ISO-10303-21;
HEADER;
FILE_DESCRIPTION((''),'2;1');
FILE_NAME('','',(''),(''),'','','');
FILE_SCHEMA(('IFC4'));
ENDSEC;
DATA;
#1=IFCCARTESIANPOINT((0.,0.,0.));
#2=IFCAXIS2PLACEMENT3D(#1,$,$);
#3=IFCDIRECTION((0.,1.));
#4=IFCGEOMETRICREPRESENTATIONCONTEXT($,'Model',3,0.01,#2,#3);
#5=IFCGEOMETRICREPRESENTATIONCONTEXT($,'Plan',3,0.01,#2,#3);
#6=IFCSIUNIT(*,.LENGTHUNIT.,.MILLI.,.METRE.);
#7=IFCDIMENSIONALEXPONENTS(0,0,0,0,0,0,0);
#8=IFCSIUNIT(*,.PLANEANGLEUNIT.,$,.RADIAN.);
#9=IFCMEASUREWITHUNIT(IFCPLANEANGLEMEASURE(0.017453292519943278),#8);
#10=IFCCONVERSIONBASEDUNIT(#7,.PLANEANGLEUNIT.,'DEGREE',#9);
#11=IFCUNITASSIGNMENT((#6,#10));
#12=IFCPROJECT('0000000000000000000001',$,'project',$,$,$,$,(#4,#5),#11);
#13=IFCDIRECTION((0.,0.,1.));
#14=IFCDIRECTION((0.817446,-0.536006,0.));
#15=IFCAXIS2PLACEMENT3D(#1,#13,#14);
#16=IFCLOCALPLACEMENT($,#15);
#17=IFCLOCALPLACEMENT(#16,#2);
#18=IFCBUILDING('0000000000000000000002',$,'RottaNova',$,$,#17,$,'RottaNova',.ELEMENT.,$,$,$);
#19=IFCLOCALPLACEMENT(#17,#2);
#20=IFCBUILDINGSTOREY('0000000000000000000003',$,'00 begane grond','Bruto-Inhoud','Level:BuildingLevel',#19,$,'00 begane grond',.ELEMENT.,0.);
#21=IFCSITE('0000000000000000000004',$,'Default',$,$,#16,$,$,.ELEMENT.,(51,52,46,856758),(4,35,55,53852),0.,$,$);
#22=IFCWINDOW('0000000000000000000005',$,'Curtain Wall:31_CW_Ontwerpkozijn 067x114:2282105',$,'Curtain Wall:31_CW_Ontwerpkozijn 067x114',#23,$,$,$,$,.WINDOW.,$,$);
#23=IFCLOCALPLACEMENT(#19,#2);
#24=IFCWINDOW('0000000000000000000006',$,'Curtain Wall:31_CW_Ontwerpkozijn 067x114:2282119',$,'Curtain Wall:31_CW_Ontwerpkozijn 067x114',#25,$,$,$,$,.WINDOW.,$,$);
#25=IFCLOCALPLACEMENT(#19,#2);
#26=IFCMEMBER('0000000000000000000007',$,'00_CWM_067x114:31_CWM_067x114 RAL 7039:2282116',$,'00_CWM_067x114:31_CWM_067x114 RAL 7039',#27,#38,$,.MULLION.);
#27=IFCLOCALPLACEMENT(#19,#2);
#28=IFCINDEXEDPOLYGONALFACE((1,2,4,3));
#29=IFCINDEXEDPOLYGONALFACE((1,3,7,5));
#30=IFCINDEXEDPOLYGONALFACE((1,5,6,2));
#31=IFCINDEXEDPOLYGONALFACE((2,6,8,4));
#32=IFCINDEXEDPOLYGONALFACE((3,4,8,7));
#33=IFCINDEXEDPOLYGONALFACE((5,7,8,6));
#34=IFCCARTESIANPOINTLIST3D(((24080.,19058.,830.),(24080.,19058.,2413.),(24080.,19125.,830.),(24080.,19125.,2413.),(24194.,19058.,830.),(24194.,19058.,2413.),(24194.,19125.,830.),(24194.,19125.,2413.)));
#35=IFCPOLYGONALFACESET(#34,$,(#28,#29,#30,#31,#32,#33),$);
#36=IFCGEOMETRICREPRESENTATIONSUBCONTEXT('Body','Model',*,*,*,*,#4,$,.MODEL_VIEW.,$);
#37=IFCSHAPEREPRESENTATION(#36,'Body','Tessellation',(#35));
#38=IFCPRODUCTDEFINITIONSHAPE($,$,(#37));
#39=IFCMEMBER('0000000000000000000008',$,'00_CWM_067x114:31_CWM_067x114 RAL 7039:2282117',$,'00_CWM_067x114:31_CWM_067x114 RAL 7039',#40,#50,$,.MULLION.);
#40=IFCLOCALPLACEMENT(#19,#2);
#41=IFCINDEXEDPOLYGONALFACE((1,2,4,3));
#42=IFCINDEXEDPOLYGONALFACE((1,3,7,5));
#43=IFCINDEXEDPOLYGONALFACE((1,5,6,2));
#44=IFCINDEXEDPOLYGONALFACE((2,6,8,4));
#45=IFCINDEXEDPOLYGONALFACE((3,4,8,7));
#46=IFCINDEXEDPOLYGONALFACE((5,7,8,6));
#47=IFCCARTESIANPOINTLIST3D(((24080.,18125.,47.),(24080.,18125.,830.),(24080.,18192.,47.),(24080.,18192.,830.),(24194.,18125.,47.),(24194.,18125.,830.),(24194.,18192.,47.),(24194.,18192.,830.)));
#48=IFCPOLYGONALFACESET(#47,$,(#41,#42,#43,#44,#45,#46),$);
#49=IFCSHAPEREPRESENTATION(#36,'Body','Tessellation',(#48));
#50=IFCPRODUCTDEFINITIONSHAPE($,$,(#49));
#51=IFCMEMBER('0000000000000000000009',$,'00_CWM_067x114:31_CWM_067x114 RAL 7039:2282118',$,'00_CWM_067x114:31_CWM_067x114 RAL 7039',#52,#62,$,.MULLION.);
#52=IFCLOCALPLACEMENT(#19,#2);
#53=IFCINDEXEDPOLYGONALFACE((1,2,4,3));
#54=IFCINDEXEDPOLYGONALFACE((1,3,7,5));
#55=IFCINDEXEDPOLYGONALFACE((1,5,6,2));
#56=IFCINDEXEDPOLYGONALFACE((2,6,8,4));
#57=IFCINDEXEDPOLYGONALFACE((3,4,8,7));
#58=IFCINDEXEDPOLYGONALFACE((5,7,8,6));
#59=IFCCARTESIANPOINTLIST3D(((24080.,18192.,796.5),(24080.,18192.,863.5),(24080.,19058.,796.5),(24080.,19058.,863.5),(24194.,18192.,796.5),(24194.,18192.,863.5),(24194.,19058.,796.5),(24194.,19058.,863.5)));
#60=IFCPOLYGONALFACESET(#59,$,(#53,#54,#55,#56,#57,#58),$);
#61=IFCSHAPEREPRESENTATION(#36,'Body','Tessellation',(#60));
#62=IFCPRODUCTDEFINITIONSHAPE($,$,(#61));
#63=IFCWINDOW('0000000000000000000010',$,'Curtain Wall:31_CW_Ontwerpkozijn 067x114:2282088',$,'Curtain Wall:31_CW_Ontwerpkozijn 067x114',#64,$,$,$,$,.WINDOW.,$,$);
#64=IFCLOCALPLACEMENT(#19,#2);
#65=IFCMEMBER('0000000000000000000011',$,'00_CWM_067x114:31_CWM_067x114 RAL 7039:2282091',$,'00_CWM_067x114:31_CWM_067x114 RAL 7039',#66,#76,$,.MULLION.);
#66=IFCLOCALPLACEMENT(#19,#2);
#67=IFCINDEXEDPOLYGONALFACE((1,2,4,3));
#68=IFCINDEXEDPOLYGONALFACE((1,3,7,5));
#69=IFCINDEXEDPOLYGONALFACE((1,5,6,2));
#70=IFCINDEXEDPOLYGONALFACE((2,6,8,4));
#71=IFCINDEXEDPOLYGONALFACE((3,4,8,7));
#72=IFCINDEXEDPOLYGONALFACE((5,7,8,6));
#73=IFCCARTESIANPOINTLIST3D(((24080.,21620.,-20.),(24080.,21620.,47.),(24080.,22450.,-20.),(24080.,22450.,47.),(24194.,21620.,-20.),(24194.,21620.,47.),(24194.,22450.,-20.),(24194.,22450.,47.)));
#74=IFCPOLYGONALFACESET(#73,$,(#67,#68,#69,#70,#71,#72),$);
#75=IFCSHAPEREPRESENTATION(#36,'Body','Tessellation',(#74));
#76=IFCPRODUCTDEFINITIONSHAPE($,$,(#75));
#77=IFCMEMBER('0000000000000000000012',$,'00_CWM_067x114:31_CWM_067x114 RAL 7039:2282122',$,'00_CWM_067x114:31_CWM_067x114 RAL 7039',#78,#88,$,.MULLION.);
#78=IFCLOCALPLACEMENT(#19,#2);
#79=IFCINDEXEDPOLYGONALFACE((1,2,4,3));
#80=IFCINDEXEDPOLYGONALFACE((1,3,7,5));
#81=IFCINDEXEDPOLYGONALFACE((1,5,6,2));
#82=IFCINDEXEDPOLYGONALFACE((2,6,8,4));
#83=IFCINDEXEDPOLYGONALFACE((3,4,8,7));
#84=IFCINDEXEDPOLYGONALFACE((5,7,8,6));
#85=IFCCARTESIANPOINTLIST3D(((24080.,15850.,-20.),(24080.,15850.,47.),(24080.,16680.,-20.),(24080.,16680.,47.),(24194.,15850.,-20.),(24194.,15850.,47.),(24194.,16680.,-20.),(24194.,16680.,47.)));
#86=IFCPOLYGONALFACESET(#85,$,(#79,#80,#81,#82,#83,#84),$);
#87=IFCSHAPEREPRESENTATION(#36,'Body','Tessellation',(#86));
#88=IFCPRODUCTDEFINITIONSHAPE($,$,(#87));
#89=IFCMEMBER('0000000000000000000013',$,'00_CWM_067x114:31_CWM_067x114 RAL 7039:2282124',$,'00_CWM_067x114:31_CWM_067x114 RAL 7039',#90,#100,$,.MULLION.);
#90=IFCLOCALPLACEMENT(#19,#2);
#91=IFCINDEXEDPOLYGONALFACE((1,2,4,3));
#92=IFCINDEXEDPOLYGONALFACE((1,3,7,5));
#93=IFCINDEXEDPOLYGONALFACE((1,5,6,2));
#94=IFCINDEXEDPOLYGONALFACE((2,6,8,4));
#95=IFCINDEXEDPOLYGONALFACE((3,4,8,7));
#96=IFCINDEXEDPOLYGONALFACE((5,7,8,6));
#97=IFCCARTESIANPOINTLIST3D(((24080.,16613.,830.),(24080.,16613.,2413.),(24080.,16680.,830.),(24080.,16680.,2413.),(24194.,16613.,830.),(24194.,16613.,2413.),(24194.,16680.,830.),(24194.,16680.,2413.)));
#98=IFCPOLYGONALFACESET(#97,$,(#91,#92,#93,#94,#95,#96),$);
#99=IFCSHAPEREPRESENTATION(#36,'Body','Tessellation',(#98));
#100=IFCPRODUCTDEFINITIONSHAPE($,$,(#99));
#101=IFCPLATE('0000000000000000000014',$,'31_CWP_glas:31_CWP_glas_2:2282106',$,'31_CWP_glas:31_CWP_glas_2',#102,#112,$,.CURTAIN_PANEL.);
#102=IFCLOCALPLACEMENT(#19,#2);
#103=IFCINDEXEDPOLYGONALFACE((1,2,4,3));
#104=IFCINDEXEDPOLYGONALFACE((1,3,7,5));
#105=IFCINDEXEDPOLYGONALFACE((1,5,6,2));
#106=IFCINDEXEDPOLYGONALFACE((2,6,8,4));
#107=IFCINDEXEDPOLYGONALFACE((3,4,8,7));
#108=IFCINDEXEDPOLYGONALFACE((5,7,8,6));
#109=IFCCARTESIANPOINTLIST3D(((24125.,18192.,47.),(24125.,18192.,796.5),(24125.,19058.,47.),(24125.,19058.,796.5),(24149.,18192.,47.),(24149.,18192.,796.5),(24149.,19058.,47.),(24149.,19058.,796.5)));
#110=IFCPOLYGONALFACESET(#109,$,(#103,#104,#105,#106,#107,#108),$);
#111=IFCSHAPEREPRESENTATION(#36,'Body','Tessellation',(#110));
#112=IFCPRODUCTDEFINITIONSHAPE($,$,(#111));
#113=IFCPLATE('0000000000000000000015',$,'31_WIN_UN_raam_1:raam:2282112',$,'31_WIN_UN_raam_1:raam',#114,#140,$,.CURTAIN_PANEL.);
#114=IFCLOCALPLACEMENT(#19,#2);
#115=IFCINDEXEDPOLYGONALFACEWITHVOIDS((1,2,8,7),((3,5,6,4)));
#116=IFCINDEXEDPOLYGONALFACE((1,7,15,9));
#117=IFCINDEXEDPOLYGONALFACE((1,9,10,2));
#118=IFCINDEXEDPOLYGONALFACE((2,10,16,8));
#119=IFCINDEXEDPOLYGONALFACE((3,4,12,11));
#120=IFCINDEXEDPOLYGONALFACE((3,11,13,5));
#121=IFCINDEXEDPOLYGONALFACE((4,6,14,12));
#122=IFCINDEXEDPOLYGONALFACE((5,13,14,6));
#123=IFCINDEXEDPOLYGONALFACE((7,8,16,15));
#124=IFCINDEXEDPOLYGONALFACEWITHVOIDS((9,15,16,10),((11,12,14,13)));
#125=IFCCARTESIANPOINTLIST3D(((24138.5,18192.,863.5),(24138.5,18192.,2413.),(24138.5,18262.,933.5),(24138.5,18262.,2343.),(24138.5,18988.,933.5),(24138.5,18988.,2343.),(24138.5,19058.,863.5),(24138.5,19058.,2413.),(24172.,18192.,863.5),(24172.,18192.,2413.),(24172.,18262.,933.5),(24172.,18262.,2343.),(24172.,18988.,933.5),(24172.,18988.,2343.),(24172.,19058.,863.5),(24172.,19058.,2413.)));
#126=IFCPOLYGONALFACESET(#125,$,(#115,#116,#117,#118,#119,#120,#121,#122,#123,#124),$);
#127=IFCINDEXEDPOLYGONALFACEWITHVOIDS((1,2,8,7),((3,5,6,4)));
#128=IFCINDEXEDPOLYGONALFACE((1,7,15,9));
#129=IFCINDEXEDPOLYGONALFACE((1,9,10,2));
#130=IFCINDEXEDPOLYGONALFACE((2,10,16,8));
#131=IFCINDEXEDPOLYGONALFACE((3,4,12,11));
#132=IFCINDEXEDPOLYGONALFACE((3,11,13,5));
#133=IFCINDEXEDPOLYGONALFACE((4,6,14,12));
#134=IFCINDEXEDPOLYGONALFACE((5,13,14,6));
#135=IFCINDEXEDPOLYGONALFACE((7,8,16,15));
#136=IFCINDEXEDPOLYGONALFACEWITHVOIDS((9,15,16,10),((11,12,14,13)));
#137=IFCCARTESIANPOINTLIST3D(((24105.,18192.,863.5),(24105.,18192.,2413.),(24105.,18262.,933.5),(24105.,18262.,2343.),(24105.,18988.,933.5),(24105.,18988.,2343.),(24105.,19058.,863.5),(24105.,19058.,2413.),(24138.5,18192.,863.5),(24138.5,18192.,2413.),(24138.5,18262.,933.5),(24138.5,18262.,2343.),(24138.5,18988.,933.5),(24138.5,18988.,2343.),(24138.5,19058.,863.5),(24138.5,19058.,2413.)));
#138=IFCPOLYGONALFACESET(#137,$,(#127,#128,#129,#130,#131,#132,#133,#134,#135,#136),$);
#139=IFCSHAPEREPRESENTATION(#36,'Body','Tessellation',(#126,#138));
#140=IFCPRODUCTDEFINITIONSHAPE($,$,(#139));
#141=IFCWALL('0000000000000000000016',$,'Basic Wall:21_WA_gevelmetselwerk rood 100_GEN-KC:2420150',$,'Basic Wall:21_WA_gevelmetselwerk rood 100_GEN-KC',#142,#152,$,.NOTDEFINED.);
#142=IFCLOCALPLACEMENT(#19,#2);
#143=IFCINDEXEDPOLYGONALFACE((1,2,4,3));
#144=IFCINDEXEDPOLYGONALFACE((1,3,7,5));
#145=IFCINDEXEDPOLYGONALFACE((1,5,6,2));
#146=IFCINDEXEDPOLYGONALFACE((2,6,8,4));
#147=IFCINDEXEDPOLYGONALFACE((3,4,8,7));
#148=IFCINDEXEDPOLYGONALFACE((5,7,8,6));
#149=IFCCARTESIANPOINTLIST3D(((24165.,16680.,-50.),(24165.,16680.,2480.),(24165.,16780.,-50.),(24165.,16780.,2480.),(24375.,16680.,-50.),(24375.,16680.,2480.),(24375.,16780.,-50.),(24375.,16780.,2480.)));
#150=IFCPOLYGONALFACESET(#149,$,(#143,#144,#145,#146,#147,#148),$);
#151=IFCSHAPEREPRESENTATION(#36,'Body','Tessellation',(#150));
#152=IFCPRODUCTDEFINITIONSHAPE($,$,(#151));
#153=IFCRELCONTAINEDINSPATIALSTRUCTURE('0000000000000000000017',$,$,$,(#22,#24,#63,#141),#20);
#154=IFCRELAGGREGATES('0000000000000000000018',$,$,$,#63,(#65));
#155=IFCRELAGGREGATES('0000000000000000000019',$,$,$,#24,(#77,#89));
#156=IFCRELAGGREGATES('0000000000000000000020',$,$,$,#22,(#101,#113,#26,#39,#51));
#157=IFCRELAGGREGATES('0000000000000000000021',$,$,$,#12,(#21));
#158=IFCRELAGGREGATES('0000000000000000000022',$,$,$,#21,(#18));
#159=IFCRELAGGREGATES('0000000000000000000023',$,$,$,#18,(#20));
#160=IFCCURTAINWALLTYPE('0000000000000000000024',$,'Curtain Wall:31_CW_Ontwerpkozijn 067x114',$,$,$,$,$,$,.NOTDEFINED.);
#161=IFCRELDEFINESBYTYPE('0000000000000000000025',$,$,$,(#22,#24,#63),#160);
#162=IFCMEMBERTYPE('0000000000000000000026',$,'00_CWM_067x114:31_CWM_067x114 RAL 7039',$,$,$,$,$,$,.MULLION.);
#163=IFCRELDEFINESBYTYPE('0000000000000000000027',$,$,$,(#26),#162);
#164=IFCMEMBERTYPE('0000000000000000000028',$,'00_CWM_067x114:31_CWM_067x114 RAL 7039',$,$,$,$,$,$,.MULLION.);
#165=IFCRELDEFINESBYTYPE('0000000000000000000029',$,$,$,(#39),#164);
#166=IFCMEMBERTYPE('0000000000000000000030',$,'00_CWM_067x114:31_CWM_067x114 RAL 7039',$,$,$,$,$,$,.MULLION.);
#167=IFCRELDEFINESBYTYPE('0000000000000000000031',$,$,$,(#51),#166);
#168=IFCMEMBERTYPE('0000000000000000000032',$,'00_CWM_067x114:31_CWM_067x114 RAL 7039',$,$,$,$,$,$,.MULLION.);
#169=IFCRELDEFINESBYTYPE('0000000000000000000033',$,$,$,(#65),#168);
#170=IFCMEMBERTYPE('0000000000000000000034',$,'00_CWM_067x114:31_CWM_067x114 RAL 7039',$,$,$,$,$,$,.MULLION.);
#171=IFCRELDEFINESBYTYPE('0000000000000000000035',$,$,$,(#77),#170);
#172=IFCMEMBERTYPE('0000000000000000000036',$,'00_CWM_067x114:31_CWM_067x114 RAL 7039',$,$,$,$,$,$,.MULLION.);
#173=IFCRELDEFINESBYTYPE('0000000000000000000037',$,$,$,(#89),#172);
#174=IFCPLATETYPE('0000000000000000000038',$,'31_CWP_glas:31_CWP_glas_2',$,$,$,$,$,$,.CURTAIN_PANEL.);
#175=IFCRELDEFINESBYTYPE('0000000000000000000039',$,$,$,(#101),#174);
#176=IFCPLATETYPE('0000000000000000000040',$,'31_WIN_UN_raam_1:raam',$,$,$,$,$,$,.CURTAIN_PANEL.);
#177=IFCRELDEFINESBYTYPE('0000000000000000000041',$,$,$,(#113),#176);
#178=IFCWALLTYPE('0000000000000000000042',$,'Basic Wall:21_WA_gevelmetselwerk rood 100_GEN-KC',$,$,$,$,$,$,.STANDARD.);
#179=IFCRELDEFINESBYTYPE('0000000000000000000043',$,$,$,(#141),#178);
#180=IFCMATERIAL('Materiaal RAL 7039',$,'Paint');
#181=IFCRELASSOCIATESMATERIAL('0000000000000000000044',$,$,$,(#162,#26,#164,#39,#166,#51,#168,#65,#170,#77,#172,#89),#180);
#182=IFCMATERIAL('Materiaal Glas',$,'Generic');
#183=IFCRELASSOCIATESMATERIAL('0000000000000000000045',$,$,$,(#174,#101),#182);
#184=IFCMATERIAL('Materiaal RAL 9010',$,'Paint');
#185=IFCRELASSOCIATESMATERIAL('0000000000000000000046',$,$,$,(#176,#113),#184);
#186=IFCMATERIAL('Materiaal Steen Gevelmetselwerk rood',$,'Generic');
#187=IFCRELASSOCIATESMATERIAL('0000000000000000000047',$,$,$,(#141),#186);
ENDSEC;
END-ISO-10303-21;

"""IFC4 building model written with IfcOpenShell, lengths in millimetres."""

from ifc_helpers import new_model, entity, si_unit, converted_unit, direction, frame, origin, place, context, subcontext, project, spatial, indexed_curve, outline, extrude, source, transform, mapped, material, type_object, type_shapes, element, aggregate, save


model = new_model("IFC4")

# Units and contexts
model_context = context("Model", 3, precision=0.01, world=origin(), true_north=direction((0.0, 1.0)))
plan_context = context("Plan", 3, precision=0.01, world=origin(), true_north=direction((0.0, 1.0)))
body_context = subcontext(model_context, "Body", "Model", "MODEL_VIEW")
ifc_project = project(units=[si_unit("LENGTHUNIT", "METRE", prefix="MILLI"), converted_unit("PLANEANGLEUNIT", "DEGREE", entity("IfcPlaneAngleMeasure", 0.017453292519943278), si_unit("PLANEANGLEUNIT", "RADIAN"), dimensions=[0, 0, 0, 0, 0, 0, 0])], contexts=[model_context, plan_context])

# Site, building, storey
site_placement = place(None, frame((0.0, 0.0, 0.0), z_axis=(0.0, 0.0, 1.0), x_axis=(0.817446, -0.536006, 0.0)))
site = spatial("IfcSite", under=ifc_project, at=site_placement, Name="Default", CompositionType="ELEMENT", RefLatitude=(51, 52, 46, 856758), RefLongitude=(4, 35, 55, 53852), RefElevation=0.0)
building_placement = place(site_placement, origin())
building = spatial("IfcBuilding", under=site, at=building_placement, Name="RottaNova", LongName="RottaNova", CompositionType="ELEMENT")
storey_placement = place(building_placement, origin())
storey = spatial("IfcBuildingStorey", under=building, at=storey_placement, Name="00 begane grond", Description="Bruto-Inhoud", ObjectType="Level:BuildingLevel", LongName="00 begane grond", CompositionType="ELEMENT", Elevation=0.0)

# Shared definitions
curtain_wall_type = type_object("IfcCurtainWallType", Name="Curtain Wall:31_CW_Ontwerpkozijn 067x114", PredefinedType="NOTDEFINED")
ifc_material_1 = material(Name="Materiaal RAL 7039", Category="Paint")

# Window
window_1_placement = place(storey_placement, origin())
window_1 = element("IfcWindow", 1, at=window_1_placement, inside=storey, type_object=curtain_wall_type, Name="Curtain Wall:31_CW_Ontwerpkozijn 067x114:2282105", ObjectType="Curtain Wall:31_CW_Ontwerpkozijn 067x114", PredefinedType="WINDOW")

# Window
window_2_placement = place(storey_placement, origin())
window_2 = element("IfcWindow", 2, at=window_2_placement, inside=storey, type_object=curtain_wall_type, Name="Curtain Wall:31_CW_Ontwerpkozijn 067x114:2282119", ObjectType="Curtain Wall:31_CW_Ontwerpkozijn 067x114", PredefinedType="WINDOW")

# Members
member_type_1 = type_object("IfcMemberType", Name="00_CWM_067x114:31_CWM_067x114 RAL 7039", PredefinedType="MULLION", material=ifc_material_1)
shared_shape_1 = source(origin(), body_context, "Body", "SweptSolid", [
    extrude(outline(indexed_curve([(-33.5, -57.0), (33.5, -57.0), (33.5, 57.0), (-33.5, 57.0), (-33.5, -57.0)], self_intersect=False)), frame((-33.5, 57.0, -1583.0), z_axis=(0.0, 0.0, 1.0), x_axis=(-1.0, 0.0, 0.0)), (0.0, 0.0, 1.0), 1583.0),
])
type_shapes(member_type_1, [shared_shape_1])
member_1_placement = place(window_1_placement, frame((24080.0, 19125.0, 830.0), z_axis=(0.0, 0.0, -1.0), x_axis=(0.0, 1.0, 0.0)))
member_1 = element("IfcMember", 3, at=member_1_placement, type_object=member_type_1, material=ifc_material_1, Name="00_CWM_067x114:31_CWM_067x114 RAL 7039:2282116", ObjectType="00_CWM_067x114:31_CWM_067x114 RAL 7039", PredefinedType="MULLION", context=body_context, shape_type="MappedRepresentation", body=[
    mapped(shared_shape_1, transform((0.0, 0.0, 0.0), scale=1.0)),
])
member_type_2 = type_object("IfcMemberType", Name="00_CWM_067x114:31_CWM_067x114 RAL 7039", PredefinedType="MULLION", material=ifc_material_1)
shared_shape_2 = source(origin(), body_context, "Body", "SweptSolid", [
    extrude(outline(indexed_curve([(-33.5, -57.0), (33.5, -57.0), (33.5, 57.0), (-33.5, 57.0), (-33.5, -57.0)], self_intersect=False)), frame((-33.5, 57.0, -783.0), z_axis=(0.0, 0.0, 1.0), x_axis=(-1.0, 0.0, 0.0)), (0.0, 0.0, 1.0), 783.0),
])
type_shapes(member_type_2, [shared_shape_2])
member_2_placement = place(window_1_placement, frame((24080.0, 18125.0, 830.0), z_axis=(0.0, 0.0, 1.0), x_axis=(0.0, -1.0, 0.0)))
member_2 = element("IfcMember", 4, at=member_2_placement, type_object=member_type_2, material=ifc_material_1, Name="00_CWM_067x114:31_CWM_067x114 RAL 7039:2282117", ObjectType="00_CWM_067x114:31_CWM_067x114 RAL 7039", PredefinedType="MULLION", context=body_context, shape_type="MappedRepresentation", body=[
    mapped(shared_shape_2, transform((0.0, 0.0, 0.0), scale=1.0)),
])
member_type_3 = type_object("IfcMemberType", Name="00_CWM_067x114:31_CWM_067x114 RAL 7039", PredefinedType="MULLION", material=ifc_material_1)
shared_shape_3 = source(origin(), body_context, "Body", "SweptSolid", [
    extrude(outline(indexed_curve([(-33.5, -57.0), (33.5, -57.0), (33.5, 57.0), (-33.5, 57.0), (-33.5, -57.0)], self_intersect=False)), frame((0.0, 57.0, -866.0), z_axis=(0.0, 0.0, 1.0), x_axis=(-1.0, 0.0, 0.0)), (0.0, 0.0, 1.0), 866.0),
])
type_shapes(member_type_3, [shared_shape_3])
member_3_placement = place(window_1_placement, frame((24080.0, 19058.0, 830.0), z_axis=(0.0, 1.0, 0.0), x_axis=(0.0, 0.0, 1.0)))
member_3 = element("IfcMember", 5, at=member_3_placement, type_object=member_type_3, material=ifc_material_1, Name="00_CWM_067x114:31_CWM_067x114 RAL 7039:2282118", ObjectType="00_CWM_067x114:31_CWM_067x114 RAL 7039", PredefinedType="MULLION", context=body_context, shape_type="MappedRepresentation", body=[
    mapped(shared_shape_3, transform((0.0, 0.0, 0.0), scale=1.0)),
])

# Window, member
window_3_placement = place(storey_placement, origin())
window_3 = element("IfcWindow", 6, at=window_3_placement, inside=storey, type_object=curtain_wall_type, Name="Curtain Wall:31_CW_Ontwerpkozijn 067x114:2282088", ObjectType="Curtain Wall:31_CW_Ontwerpkozijn 067x114", PredefinedType="WINDOW")
member_type_4 = type_object("IfcMemberType", Name="00_CWM_067x114:31_CWM_067x114 RAL 7039", PredefinedType="MULLION", material=ifc_material_1)
shared_shape_4 = source(origin(), body_context, "Body", "SweptSolid", [
    extrude(outline(indexed_curve([(-33.5, -57.0), (33.5, -57.0), (33.5, 57.0), (-33.5, 57.0), (-33.5, -57.0)], self_intersect=False)), frame((-33.5, 57.0, -830.0), z_axis=(0.0, 0.0, 1.0), x_axis=(-1.0, 0.0, 0.0)), (0.0, 0.0, 1.0), 830.0),
])
type_shapes(member_type_4, [shared_shape_4])
member_4_placement = place(window_3_placement, frame((24080.0, 21620.0, -20.0), z_axis=(0.0, -1.0, 0.0), x_axis=(0.0, 0.0, -1.0)))
member_4 = element("IfcMember", 7, at=member_4_placement, type_object=member_type_4, material=ifc_material_1, Name="00_CWM_067x114:31_CWM_067x114 RAL 7039:2282091", ObjectType="00_CWM_067x114:31_CWM_067x114 RAL 7039", PredefinedType="MULLION", context=body_context, shape_type="MappedRepresentation", body=[
    mapped(shared_shape_4, transform((0.0, 0.0, 0.0), scale=1.0)),
])
aggregate(window_3, [member_4])

# Members
member_type_5 = type_object("IfcMemberType", Name="00_CWM_067x114:31_CWM_067x114 RAL 7039", PredefinedType="MULLION", material=ifc_material_1)
shared_shape_5 = source(origin(), body_context, "Body", "SweptSolid", [
    extrude(outline(indexed_curve([(-33.5, -57.0), (33.5, -57.0), (33.5, 57.0), (-33.5, 57.0), (-33.5, -57.0)], self_intersect=False)), frame((-33.5, -57.0, -830.0), z_axis=(0.0, 0.0, 1.0), x_axis=(-1.0, 0.0, 0.0)), (0.0, 0.0, 1.0), 830.0),
])
type_shapes(member_type_5, [shared_shape_5])
member_5_placement = place(window_2_placement, frame((24080.0, 16680.0, -20.0), z_axis=(0.0, 1.0, 0.0), x_axis=(0.0, 0.0, -1.0)))
member_5 = element("IfcMember", 8, at=member_5_placement, type_object=member_type_5, material=ifc_material_1, Name="00_CWM_067x114:31_CWM_067x114 RAL 7039:2282122", ObjectType="00_CWM_067x114:31_CWM_067x114 RAL 7039", PredefinedType="MULLION", context=body_context, shape_type="MappedRepresentation", body=[
    mapped(shared_shape_5, transform((0.0, 0.0, 0.0), scale=1.0)),
])
member_type_6 = type_object("IfcMemberType", Name="00_CWM_067x114:31_CWM_067x114 RAL 7039", PredefinedType="MULLION", material=ifc_material_1)
shared_shape_6 = source(origin(), body_context, "Body", "SweptSolid", [
    extrude(outline(indexed_curve([(-33.5, -57.0), (33.5, -57.0), (33.5, 57.0), (-33.5, 57.0), (-33.5, -57.0)], self_intersect=False)), frame((-33.5, -57.0, -1583.0), z_axis=(0.0, 0.0, 1.0), x_axis=(-1.0, 0.0, 0.0)), (0.0, 0.0, 1.0), 1583.0),
])
type_shapes(member_type_6, [shared_shape_6])
member_6_placement = place(window_2_placement, frame((24080.0, 16680.0, 2413.0), z_axis=(0.0, 0.0, 1.0), x_axis=(0.0, 1.0, 0.0)))
member_6 = element("IfcMember", 9, at=member_6_placement, type_object=member_type_6, material=ifc_material_1, Name="00_CWM_067x114:31_CWM_067x114 RAL 7039:2282124", ObjectType="00_CWM_067x114:31_CWM_067x114 RAL 7039", PredefinedType="MULLION", context=body_context, shape_type="MappedRepresentation", body=[
    mapped(shared_shape_6, transform((0.0, 0.0, 0.0), scale=1.0)),
])
aggregate(window_2, [member_5, member_6])

# Plates
ifc_material_2 = material(Name="Materiaal Glas", Category="Generic")
plate_type_1 = type_object("IfcPlateType", Name="31_CWP_glas:31_CWP_glas_2", PredefinedType="CURTAIN_PANEL", material=ifc_material_2)
shared_shape_7 = source(origin(), body_context, "Body", "SweptSolid", [
    extrude(outline(indexed_curve([(-12.0, -433.0), (12.0, -433.0), (12.0, 433.0), (-12.0, 433.0), (-12.0, -433.0)], self_intersect=False)), frame((0.0, -57.0, 0.0), z_axis=(0.0, 0.0, 1.0), x_axis=(0.0, 1.0, 0.0)), (0.0, 0.0, 1.0), 749.5),
])
type_shapes(plate_type_1, [shared_shape_7])
plate_1_placement = place(window_1_placement, frame((24080.0, 18625.0, 47.0), z_axis=(0.0, 0.0, 1.0), x_axis=(0.0, 1.0, 0.0)))
plate_1 = element("IfcPlate", 10, at=plate_1_placement, type_object=plate_type_1, material=ifc_material_2, Name="31_CWP_glas:31_CWP_glas_2:2282106", ObjectType="31_CWP_glas:31_CWP_glas_2", PredefinedType="CURTAIN_PANEL", context=body_context, shape_type="MappedRepresentation", body=[
    mapped(shared_shape_7, transform((0.0, 0.0, 0.0), scale=1.0)),
])
ifc_material_3 = material(Name="Materiaal RAL 9010", Category="Paint")
plate_type_2 = type_object("IfcPlateType", Name="31_WIN_UN_raam_1:raam", PredefinedType="CURTAIN_PANEL", material=ifc_material_3)
shared_shape_8 = source(origin(), body_context, "Body", "SweptSolid", [
    extrude(outline(indexed_curve([(-433.0, -774.7), (433.0, -774.7), (433.0, 774.7), (-433.0, 774.7), (-433.0, -774.7)], self_intersect=False), holes=[indexed_curve([(-363.0, 704.7), (363.0, 704.7), (363.0, -704.8), (-363.0, -704.8), (-363.0, 704.7)], self_intersect=False)]), frame((0.0, -92.0, 774.8), z_axis=(0.0, 1.0, 0.0), x_axis=(1.0, 0.0, 0.0)), (0.0, 0.0, 1.0), 33.5),
    extrude(outline(indexed_curve([(-433.0, -774.7), (433.0, -774.7), (433.0, 774.7), (-433.0, 774.7), (-433.0, -774.7)], self_intersect=False), holes=[indexed_curve([(-363.0, 704.7), (363.0, 704.7), (363.0, -704.8), (-363.0, -704.8), (-363.0, 704.7)], self_intersect=False)]), frame((0.0, -58.5, 774.8), z_axis=(0.0, 1.0, 0.0), x_axis=(1.0, 0.0, 0.0)), (0.0, 0.0, 1.0), 33.5),
])
type_shapes(plate_type_2, [shared_shape_8])
plate_2_placement = place(window_1_placement, frame((24080.0, 18625.0, 863.5), z_axis=(0.0, 0.0, 1.0), x_axis=(0.0, 1.0, 0.0)))
plate_2 = element("IfcPlate", 11, at=plate_2_placement, type_object=plate_type_2, material=ifc_material_3, Name="31_WIN_UN_raam_1:raam:2282112", ObjectType="31_WIN_UN_raam_1:raam", PredefinedType="CURTAIN_PANEL", context=body_context, shape_type="MappedRepresentation", body=[
    mapped(shared_shape_8, transform((0.0, 0.0, 0.0), scale=1.0)),
])
aggregate(window_1, [plate_1, plate_2, member_1, member_2, member_3])

# Wall
ifc_material_4 = material(Name="Materiaal Steen Gevelmetselwerk rood", Category="Generic")
wall_type_1 = type_object("IfcWallType", Name="Basic Wall:21_WA_gevelmetselwerk rood 100_GEN-KC", PredefinedType="STANDARD")
wall_1_placement = place(storey_placement, frame((24375.0, 16730.0, -50.0), z_axis=(0.0, 0.0, 1.0), x_axis=(-1.0, 0.0, 0.0)))
element("IfcWall", 12, at=wall_1_placement, inside=storey, type_object=wall_type_1, material=ifc_material_4, Name="Basic Wall:21_WA_gevelmetselwerk rood 100_GEN-KC:2420150", ObjectType="Basic Wall:21_WA_gevelmetselwerk rood 100_GEN-KC", PredefinedType="NOTDEFINED", context=body_context, shape_type="SweptSolid", body=[
    extrude(outline(indexed_curve([(210.0, 50.0), (0.0, 50.0), (0.0, -50.0), (210.0, -50.0), (210.0, 50.0)], self_intersect=False)), origin(), (0.0, 0.0, 1.0), 2530.0),
])

save(model, "model.ifc")
